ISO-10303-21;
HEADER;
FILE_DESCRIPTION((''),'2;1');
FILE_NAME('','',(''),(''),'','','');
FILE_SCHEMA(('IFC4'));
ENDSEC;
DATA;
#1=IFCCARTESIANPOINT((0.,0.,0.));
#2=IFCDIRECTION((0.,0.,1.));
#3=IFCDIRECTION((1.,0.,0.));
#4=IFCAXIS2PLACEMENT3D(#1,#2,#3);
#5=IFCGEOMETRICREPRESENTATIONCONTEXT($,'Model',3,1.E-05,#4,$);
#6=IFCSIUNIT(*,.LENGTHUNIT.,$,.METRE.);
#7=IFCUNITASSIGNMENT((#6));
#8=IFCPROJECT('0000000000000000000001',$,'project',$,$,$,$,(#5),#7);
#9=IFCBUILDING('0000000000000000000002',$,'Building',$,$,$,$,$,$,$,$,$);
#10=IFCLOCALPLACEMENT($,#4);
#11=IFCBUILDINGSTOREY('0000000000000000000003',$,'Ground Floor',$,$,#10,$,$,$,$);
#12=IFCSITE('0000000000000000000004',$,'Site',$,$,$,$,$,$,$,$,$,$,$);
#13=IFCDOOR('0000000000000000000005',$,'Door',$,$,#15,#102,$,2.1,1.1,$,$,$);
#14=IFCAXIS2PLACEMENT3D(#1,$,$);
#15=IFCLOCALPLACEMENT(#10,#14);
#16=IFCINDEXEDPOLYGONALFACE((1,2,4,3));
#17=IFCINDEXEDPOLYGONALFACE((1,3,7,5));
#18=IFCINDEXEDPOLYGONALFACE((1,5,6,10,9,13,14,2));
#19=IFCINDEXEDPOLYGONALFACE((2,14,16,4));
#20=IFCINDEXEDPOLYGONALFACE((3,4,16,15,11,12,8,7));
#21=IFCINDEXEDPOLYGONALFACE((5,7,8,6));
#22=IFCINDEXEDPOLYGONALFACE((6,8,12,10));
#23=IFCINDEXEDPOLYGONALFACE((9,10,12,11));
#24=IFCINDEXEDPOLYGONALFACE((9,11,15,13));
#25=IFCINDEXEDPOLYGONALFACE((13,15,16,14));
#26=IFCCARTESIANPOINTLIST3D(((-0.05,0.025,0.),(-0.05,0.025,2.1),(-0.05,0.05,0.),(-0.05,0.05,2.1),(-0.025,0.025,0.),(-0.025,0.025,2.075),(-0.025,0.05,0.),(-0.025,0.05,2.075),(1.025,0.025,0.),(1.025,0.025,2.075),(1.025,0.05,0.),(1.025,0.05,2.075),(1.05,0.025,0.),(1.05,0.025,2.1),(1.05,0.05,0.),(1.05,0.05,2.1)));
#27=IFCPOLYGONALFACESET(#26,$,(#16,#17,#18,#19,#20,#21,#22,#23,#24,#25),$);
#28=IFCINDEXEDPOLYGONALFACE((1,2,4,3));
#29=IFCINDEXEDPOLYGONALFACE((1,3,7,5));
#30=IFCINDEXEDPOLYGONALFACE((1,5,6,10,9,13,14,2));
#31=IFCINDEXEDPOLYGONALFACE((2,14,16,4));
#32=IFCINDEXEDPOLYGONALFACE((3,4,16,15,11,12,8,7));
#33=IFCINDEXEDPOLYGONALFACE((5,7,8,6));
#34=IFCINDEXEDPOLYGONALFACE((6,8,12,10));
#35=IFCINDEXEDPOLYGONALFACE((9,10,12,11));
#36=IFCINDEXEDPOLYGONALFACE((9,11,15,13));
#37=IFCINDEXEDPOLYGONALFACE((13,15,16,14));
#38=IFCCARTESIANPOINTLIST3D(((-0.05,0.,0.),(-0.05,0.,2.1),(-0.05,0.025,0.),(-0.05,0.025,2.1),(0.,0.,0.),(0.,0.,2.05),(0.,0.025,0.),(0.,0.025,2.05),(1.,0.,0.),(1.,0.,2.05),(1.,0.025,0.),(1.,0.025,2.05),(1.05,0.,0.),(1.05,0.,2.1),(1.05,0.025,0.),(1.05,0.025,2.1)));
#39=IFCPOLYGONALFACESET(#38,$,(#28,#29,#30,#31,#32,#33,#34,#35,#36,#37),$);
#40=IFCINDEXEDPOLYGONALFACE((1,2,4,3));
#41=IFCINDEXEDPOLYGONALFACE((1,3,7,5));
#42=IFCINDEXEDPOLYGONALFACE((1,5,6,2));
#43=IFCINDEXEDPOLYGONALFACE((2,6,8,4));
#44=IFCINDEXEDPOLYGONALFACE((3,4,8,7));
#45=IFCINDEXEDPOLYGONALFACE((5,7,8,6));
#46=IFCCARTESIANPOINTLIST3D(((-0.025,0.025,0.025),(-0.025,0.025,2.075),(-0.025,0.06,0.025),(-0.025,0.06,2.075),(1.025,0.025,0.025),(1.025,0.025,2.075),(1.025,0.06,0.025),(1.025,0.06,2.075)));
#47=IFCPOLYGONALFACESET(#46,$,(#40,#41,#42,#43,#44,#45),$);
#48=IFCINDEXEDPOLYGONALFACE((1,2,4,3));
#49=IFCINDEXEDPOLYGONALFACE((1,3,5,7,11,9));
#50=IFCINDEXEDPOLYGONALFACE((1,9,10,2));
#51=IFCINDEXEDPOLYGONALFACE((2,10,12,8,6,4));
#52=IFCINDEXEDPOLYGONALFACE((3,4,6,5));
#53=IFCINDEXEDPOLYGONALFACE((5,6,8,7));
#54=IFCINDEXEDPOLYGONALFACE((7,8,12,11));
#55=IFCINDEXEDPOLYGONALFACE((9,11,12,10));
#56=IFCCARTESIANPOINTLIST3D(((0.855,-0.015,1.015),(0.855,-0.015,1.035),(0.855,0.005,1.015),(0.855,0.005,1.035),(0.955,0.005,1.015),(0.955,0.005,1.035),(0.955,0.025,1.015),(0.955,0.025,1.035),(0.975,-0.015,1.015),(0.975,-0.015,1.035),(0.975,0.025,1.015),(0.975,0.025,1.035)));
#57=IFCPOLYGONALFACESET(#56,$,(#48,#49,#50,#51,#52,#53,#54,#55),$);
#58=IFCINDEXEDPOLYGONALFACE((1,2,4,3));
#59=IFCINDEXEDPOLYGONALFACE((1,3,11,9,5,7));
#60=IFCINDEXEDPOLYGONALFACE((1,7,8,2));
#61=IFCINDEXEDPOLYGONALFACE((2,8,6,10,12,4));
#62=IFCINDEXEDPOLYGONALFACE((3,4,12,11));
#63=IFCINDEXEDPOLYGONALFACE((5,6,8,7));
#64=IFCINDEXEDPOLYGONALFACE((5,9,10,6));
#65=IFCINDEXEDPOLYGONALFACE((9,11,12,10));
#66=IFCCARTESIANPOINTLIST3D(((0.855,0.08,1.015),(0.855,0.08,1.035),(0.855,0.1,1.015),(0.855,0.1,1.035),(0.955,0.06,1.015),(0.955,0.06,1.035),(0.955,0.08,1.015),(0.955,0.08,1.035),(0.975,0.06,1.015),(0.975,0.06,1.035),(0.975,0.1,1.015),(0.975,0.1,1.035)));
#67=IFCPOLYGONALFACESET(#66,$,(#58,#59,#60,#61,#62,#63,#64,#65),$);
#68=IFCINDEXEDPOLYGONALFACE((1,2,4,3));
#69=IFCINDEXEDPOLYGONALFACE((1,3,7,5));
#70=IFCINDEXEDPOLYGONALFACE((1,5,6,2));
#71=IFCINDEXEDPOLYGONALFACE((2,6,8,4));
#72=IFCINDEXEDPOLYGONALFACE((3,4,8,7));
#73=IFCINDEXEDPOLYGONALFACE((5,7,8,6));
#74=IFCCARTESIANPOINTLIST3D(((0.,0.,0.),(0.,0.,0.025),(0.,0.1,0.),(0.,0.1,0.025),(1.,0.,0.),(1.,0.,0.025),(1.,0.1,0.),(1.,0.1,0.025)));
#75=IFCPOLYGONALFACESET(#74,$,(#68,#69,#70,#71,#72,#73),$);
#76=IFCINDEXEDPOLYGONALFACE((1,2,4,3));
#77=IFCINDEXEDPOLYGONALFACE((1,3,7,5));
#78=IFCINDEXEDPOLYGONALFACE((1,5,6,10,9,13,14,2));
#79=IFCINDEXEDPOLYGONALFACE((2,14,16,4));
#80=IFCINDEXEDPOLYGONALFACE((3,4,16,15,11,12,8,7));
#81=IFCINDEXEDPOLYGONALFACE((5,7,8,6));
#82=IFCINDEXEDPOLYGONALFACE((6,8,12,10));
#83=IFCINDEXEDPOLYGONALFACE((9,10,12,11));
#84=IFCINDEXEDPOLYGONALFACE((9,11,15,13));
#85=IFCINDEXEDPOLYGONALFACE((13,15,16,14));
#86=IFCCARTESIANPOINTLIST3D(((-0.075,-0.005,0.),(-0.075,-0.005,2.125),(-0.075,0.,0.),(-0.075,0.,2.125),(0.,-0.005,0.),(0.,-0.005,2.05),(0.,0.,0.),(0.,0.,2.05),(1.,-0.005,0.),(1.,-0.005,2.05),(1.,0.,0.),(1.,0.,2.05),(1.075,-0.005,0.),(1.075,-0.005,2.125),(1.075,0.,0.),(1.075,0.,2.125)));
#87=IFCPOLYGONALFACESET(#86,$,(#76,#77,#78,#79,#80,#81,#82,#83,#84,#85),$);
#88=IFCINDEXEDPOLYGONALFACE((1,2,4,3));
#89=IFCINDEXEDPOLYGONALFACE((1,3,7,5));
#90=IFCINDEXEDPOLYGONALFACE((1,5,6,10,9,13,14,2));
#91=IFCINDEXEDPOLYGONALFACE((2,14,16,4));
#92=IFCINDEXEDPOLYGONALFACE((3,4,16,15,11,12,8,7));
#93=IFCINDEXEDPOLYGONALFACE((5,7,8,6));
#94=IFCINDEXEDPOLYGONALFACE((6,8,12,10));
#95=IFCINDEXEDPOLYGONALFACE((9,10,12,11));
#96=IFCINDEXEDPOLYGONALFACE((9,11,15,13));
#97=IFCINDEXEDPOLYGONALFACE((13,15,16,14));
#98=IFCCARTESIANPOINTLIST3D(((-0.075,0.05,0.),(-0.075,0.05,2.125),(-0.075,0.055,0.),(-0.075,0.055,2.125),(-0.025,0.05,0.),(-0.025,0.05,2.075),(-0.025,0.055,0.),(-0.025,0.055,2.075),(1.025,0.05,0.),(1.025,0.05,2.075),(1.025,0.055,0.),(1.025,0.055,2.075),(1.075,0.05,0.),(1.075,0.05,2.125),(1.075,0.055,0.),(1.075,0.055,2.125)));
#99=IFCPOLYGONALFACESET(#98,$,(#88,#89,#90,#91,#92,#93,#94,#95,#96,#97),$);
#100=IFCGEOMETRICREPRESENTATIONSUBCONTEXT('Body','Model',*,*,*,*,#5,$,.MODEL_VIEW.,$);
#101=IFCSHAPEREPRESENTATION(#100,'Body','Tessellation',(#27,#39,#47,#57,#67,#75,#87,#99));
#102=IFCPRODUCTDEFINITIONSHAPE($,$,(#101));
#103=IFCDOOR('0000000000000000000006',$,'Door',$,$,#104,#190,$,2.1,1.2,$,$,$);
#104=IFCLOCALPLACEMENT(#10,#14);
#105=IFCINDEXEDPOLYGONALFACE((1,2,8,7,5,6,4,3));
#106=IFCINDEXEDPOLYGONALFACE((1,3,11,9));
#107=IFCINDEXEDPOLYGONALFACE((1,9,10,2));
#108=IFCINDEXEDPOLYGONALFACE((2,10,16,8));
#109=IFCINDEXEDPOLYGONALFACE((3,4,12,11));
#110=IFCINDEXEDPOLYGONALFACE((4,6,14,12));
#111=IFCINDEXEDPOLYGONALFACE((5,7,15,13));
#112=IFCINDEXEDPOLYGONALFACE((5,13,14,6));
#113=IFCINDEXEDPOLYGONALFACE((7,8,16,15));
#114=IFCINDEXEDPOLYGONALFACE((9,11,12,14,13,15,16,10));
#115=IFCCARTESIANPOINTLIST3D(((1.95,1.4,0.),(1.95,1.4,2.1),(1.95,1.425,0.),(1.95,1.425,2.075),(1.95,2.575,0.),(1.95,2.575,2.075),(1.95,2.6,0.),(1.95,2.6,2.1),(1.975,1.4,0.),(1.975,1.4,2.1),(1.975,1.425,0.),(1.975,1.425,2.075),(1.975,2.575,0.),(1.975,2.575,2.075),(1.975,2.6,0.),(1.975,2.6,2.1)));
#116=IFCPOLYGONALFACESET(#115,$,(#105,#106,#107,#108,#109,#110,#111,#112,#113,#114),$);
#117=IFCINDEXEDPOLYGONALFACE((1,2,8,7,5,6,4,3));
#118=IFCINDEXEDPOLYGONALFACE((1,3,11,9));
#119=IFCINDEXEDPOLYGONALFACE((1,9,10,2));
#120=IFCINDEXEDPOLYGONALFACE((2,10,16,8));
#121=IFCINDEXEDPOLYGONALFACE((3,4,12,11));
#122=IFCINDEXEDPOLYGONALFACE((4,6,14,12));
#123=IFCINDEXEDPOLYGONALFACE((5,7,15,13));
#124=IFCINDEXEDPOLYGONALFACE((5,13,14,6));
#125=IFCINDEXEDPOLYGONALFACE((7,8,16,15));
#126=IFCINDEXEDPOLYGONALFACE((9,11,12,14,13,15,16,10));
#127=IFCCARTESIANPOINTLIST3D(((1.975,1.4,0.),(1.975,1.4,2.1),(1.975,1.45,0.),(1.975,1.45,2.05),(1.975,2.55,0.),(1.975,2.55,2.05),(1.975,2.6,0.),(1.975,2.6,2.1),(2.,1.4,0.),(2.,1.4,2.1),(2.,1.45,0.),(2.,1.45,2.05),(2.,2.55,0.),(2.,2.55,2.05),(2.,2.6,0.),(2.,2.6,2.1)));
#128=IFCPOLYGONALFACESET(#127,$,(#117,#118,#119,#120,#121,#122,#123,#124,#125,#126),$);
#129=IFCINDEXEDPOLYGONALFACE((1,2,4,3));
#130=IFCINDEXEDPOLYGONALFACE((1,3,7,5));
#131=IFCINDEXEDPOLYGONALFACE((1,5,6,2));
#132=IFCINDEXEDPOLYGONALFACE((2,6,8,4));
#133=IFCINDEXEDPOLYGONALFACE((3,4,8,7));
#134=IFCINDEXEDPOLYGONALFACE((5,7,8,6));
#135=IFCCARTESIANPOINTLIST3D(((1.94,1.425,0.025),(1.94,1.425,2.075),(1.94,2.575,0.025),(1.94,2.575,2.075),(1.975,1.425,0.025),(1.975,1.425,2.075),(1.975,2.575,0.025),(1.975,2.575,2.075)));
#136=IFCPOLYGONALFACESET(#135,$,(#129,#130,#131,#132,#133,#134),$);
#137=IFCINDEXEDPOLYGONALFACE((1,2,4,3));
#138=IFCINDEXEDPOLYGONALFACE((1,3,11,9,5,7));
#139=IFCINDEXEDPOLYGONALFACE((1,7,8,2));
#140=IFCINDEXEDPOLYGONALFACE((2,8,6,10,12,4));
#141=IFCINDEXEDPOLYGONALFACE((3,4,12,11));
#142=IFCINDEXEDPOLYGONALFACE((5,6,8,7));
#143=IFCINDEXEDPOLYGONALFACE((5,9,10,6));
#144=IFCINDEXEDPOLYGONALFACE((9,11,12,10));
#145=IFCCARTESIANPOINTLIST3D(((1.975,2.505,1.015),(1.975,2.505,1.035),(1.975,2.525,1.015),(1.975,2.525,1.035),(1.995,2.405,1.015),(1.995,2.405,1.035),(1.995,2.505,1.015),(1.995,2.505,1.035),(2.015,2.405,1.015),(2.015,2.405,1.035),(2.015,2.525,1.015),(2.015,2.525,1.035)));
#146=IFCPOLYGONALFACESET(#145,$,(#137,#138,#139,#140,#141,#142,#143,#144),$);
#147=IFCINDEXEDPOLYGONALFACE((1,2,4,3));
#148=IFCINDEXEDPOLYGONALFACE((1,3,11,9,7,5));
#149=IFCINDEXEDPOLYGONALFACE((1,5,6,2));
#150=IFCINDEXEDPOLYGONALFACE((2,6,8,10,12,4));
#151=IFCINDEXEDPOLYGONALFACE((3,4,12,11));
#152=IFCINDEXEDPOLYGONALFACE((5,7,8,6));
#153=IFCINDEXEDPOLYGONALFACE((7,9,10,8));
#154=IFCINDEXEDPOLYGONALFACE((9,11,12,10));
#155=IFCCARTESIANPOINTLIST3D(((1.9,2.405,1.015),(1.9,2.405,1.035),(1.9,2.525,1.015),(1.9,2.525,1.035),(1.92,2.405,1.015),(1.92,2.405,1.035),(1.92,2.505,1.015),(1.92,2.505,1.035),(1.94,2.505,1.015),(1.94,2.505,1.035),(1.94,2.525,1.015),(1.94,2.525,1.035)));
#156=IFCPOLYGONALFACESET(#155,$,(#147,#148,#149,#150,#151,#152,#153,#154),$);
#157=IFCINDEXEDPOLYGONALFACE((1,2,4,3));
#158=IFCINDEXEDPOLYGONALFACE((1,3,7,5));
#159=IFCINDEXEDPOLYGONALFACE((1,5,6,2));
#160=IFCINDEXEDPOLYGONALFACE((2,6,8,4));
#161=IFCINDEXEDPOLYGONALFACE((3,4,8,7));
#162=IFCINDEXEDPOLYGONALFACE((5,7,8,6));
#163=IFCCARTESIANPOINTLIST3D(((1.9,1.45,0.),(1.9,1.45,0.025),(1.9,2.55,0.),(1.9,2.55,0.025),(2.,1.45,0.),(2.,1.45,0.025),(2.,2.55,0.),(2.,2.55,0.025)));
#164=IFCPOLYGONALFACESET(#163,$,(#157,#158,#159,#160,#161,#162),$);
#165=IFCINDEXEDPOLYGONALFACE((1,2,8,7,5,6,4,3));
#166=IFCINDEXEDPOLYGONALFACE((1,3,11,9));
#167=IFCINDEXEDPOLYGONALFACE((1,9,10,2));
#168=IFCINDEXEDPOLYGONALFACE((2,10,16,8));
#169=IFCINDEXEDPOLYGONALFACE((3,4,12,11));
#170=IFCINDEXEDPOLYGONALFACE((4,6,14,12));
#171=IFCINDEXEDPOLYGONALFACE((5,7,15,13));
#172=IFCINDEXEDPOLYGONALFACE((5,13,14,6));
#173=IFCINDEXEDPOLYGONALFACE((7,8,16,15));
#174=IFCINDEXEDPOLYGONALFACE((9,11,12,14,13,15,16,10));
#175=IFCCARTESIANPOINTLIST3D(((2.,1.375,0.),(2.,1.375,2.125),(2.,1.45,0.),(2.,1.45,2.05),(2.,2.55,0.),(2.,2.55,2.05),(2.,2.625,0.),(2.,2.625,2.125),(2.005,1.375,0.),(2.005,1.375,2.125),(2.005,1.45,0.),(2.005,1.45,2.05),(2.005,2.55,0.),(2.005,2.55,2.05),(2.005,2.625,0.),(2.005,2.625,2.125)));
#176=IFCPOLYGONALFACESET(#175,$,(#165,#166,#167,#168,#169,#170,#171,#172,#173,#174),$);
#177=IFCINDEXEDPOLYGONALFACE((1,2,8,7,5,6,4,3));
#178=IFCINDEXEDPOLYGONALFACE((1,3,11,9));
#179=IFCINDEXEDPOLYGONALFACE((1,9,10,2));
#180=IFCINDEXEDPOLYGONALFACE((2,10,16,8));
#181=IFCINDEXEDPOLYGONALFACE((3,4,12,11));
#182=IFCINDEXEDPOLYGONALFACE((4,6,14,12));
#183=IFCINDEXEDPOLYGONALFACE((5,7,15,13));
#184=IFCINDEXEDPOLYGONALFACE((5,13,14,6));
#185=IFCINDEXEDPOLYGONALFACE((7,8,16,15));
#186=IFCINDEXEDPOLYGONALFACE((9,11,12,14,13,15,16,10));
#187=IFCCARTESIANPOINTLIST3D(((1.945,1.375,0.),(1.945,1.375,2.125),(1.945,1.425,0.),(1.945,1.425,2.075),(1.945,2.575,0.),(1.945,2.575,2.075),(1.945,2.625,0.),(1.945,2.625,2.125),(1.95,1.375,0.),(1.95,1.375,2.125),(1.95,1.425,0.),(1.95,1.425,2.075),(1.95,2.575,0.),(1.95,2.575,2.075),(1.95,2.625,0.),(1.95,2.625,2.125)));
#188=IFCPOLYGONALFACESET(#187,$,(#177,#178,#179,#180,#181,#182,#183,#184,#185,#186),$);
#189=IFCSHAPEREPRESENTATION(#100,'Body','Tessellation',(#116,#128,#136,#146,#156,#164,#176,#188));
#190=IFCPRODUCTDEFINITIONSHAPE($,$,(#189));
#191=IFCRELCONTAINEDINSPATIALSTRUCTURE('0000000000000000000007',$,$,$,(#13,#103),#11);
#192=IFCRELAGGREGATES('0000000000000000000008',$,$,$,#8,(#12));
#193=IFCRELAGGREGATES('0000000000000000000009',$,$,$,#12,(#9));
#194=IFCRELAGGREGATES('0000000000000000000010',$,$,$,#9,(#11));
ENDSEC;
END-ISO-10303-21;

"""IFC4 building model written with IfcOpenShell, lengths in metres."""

from ifc_helpers import new_model, si_unit, frame, origin_with_axes, place, context, subcontext, project, spatial, line, indexed_curve, outline, extrude, element, save


model = new_model("IFC4")

# Units and contexts
model_context = context("Model", 3, precision=1e-05, world=origin_with_axes())
body_context = subcontext(model_context, "Body", "Model", "MODEL_VIEW")
ifc_project = project(units=[si_unit("LENGTHUNIT", "METRE")], contexts=[model_context])

# Site, building, storey
site = spatial("IfcSite", under=ifc_project, Name="Site")
building = spatial("IfcBuilding", under=site, Name="Building")
storey_placement = place(None, origin_with_axes())
storey = spatial("IfcBuildingStorey", under=building, at=storey_placement, Name="Ground Floor")

# Doors
door_1_placement = place(storey_placement, frame((-0.05, 0.0, 0.0), z_axis=(0.0, 0.0, 1.0), x_axis=(1.0, 0.0, 0.0)))
element("IfcDoor", 1, at=door_1_placement, inside=storey, Name="Door", OverallHeight=2.1, OverallWidth=1.1, context=body_context, shape_type="SweptSolid", body=[
    extrude(outline(indexed_curve([(0.0, 0.0), (0.0, 2.1), (1.1, 2.1), (1.1, 0.0), (1.075, 0.0), (1.075, 2.075), (0.025, 2.075), (0.025, 0.0)], segments=[line(1, 2, 3, 4, 5, 6, 7, 8, 1)])), frame((0.0, 0.025, 0.0), z_axis=(0.0, -1.0, 0.0), x_axis=(1.0, 0.0, 0.0)), (0.0, 0.0, -1.0), 0.025),
    extrude(outline(indexed_curve([(0.0, 0.0), (0.0, 2.1), (1.1, 2.1), (1.1, 0.0), (1.05, 0.0), (1.05, 2.05), (0.05, 2.05), (0.05, 0.0)], segments=[line(1, 2, 3, 4, 5, 6, 7, 8, 1)])), frame((0.0, 0.0, 0.0), z_axis=(0.0, -1.0, 0.0), x_axis=(1.0, 0.0, 0.0)), (0.0, 0.0, -1.0), 0.025),
    extrude(outline(indexed_curve([(0.0, 0.0), (1.05, 0.0), (1.05, 0.035), (0.0, 0.035)], segments=[line(1, 2, 3, 4, 1)])), frame((0.025, 0.025, 0.025), z_axis=(0.0, 0.0, 1.0), x_axis=(1.0, 0.0, 0.0)), (0.0, 0.0, 1.0), 2.05),
    extrude(outline(indexed_curve([(0.0, 0.0), (0.0, -0.04), (-0.12, -0.04), (-0.12, -0.02), (-0.02, -0.02), (-0.02, 0.0)], segments=[line(1, 2, 3, 4, 5, 6, 1)])), frame((1.025, 0.025, 1.015), z_axis=(0.0, 0.0, 1.0), x_axis=(1.0, 0.0, 0.0)), (0.0, 0.0, 1.0), 0.02),
    extrude(outline(indexed_curve([(0.0, 0.0), (0.0, 0.04), (-0.12, 0.04), (-0.12, 0.02), (-0.02, 0.02), (-0.02, 0.0)], segments=[line(1, 2, 3, 4, 5, 6, 1)])), frame((1.025, 0.06, 1.015), z_axis=(0.0, 0.0, 1.0), x_axis=(1.0, 0.0, 0.0)), (0.0, 0.0, 1.0), 0.02),
    extrude(outline(indexed_curve([(0.0, 0.0), (1.0, 0.0), (1.0, 0.1), (0.0, 0.1)], segments=[line(1, 2, 3, 4, 1)])), frame((0.05, 0.0, 0.0), z_axis=(0.0, 0.0, 1.0), x_axis=(1.0, 0.0, 0.0)), (0.0, 0.0, 1.0), 0.025),
    extrude(outline(indexed_curve([(0.0, 0.0), (0.0, 2.125), (1.15, 2.125), (1.15, 0.0), (1.075, 0.0), (1.075, 2.05), (0.075, 2.05), (0.075, 0.0)], segments=[line(1, 2, 3, 4, 5, 6, 7, 8, 1)])), frame((-0.025, -0.005, 0.0), z_axis=(0.0, -1.0, 0.0), x_axis=(1.0, 0.0, 0.0)), (0.0, 0.0, -1.0), 0.005),
    extrude(outline(indexed_curve([(0.0, 0.0), (0.0, 2.125), (1.15, 2.125), (1.15, 0.0), (1.1, 0.0), (1.1, 2.075), (0.05, 2.075), (0.05, 0.0)], segments=[line(1, 2, 3, 4, 5, 6, 7, 8, 1)])), frame((-0.025, 0.05, 0.0), z_axis=(0.0, -1.0, 0.0), x_axis=(1.0, 0.0, 0.0)), (0.0, 0.0, -1.0), 0.005),
])
door_2_placement = place(storey_placement, frame((2.0, 1.4, 0.0), z_axis=(0.0, 0.0, 1.0), x_axis=(0.0, 1.0, 0.0)))
element("IfcDoor", 2, at=door_2_placement, inside=storey, Name="Door", OverallHeight=2.1, OverallWidth=1.2, context=body_context, shape_type="SweptSolid", body=[
    extrude(outline(indexed_curve([(0.0, 0.0), (0.0, 2.1), (1.2, 2.1), (1.2, 0.0), (1.175, 0.0), (1.175, 2.075), (0.025, 2.075), (0.025, 0.0)], segments=[line(1, 2, 3, 4, 5, 6, 7, 8, 1)])), frame((0.0, 0.025, 0.0), z_axis=(0.0, -1.0, 0.0), x_axis=(1.0, 0.0, 0.0)), (0.0, 0.0, -1.0), 0.025),
    extrude(outline(indexed_curve([(0.0, 0.0), (0.0, 2.1), (1.2, 2.1), (1.2, 0.0), (1.15, 0.0), (1.15, 2.05), (0.05, 2.05), (0.05, 0.0)], segments=[line(1, 2, 3, 4, 5, 6, 7, 8, 1)])), frame((0.0, 0.0, 0.0), z_axis=(0.0, -1.0, 0.0), x_axis=(1.0, 0.0, 0.0)), (0.0, 0.0, -1.0), 0.025),
    extrude(outline(indexed_curve([(0.0, 0.0), (1.15, 0.0), (1.15, 0.035), (0.0, 0.035)], segments=[line(1, 2, 3, 4, 1)])), frame((0.025, 0.025, 0.025), z_axis=(0.0, 0.0, 1.0), x_axis=(1.0, 0.0, 0.0)), (0.0, 0.0, 1.0), 2.05),
    extrude(outline(indexed_curve([(0.0, 0.0), (0.0, -0.04), (-0.12, -0.04), (-0.12, -0.02), (-0.02, -0.02), (-0.02, 0.0)], segments=[line(1, 2, 3, 4, 5, 6, 1)])), frame((1.125, 0.025, 1.015), z_axis=(0.0, 0.0, 1.0), x_axis=(1.0, 0.0, 0.0)), (0.0, 0.0, 1.0), 0.02),
    extrude(outline(indexed_curve([(0.0, 0.0), (0.0, 0.04), (-0.12, 0.04), (-0.12, 0.02), (-0.02, 0.02), (-0.02, 0.0)], segments=[line(1, 2, 3, 4, 5, 6, 1)])), frame((1.125, 0.06, 1.015), z_axis=(0.0, 0.0, 1.0), x_axis=(1.0, 0.0, 0.0)), (0.0, 0.0, 1.0), 0.02),
    extrude(outline(indexed_curve([(0.0, 0.0), (1.1, 0.0), (1.1, 0.1), (0.0, 0.1)], segments=[line(1, 2, 3, 4, 1)])), frame((0.05, 0.0, 0.0), z_axis=(0.0, 0.0, 1.0), x_axis=(1.0, 0.0, 0.0)), (0.0, 0.0, 1.0), 0.025),
    extrude(outline(indexed_curve([(0.0, 0.0), (0.0, 2.125), (1.25, 2.125), (1.25, 0.0), (1.175, 0.0), (1.175, 2.05), (0.075, 2.05), (0.075, 0.0)], segments=[line(1, 2, 3, 4, 5, 6, 7, 8, 1)])), frame((-0.025, -0.005, 0.0), z_axis=(0.0, -1.0, 0.0), x_axis=(1.0, 0.0, 0.0)), (0.0, 0.0, -1.0), 0.005),
    extrude(outline(indexed_curve([(0.0, 0.0), (0.0, 2.125), (1.25, 2.125), (1.25, 0.0), (1.2, 0.0), (1.2, 2.075), (0.05, 2.075), (0.05, 0.0)], segments=[line(1, 2, 3, 4, 5, 6, 7, 8, 1)])), frame((-0.025, 0.05, 0.0), z_axis=(0.0, -1.0, 0.0), x_axis=(1.0, 0.0, 0.0)), (0.0, 0.0, -1.0), 0.005),
])

save(model, "model.ifc")
